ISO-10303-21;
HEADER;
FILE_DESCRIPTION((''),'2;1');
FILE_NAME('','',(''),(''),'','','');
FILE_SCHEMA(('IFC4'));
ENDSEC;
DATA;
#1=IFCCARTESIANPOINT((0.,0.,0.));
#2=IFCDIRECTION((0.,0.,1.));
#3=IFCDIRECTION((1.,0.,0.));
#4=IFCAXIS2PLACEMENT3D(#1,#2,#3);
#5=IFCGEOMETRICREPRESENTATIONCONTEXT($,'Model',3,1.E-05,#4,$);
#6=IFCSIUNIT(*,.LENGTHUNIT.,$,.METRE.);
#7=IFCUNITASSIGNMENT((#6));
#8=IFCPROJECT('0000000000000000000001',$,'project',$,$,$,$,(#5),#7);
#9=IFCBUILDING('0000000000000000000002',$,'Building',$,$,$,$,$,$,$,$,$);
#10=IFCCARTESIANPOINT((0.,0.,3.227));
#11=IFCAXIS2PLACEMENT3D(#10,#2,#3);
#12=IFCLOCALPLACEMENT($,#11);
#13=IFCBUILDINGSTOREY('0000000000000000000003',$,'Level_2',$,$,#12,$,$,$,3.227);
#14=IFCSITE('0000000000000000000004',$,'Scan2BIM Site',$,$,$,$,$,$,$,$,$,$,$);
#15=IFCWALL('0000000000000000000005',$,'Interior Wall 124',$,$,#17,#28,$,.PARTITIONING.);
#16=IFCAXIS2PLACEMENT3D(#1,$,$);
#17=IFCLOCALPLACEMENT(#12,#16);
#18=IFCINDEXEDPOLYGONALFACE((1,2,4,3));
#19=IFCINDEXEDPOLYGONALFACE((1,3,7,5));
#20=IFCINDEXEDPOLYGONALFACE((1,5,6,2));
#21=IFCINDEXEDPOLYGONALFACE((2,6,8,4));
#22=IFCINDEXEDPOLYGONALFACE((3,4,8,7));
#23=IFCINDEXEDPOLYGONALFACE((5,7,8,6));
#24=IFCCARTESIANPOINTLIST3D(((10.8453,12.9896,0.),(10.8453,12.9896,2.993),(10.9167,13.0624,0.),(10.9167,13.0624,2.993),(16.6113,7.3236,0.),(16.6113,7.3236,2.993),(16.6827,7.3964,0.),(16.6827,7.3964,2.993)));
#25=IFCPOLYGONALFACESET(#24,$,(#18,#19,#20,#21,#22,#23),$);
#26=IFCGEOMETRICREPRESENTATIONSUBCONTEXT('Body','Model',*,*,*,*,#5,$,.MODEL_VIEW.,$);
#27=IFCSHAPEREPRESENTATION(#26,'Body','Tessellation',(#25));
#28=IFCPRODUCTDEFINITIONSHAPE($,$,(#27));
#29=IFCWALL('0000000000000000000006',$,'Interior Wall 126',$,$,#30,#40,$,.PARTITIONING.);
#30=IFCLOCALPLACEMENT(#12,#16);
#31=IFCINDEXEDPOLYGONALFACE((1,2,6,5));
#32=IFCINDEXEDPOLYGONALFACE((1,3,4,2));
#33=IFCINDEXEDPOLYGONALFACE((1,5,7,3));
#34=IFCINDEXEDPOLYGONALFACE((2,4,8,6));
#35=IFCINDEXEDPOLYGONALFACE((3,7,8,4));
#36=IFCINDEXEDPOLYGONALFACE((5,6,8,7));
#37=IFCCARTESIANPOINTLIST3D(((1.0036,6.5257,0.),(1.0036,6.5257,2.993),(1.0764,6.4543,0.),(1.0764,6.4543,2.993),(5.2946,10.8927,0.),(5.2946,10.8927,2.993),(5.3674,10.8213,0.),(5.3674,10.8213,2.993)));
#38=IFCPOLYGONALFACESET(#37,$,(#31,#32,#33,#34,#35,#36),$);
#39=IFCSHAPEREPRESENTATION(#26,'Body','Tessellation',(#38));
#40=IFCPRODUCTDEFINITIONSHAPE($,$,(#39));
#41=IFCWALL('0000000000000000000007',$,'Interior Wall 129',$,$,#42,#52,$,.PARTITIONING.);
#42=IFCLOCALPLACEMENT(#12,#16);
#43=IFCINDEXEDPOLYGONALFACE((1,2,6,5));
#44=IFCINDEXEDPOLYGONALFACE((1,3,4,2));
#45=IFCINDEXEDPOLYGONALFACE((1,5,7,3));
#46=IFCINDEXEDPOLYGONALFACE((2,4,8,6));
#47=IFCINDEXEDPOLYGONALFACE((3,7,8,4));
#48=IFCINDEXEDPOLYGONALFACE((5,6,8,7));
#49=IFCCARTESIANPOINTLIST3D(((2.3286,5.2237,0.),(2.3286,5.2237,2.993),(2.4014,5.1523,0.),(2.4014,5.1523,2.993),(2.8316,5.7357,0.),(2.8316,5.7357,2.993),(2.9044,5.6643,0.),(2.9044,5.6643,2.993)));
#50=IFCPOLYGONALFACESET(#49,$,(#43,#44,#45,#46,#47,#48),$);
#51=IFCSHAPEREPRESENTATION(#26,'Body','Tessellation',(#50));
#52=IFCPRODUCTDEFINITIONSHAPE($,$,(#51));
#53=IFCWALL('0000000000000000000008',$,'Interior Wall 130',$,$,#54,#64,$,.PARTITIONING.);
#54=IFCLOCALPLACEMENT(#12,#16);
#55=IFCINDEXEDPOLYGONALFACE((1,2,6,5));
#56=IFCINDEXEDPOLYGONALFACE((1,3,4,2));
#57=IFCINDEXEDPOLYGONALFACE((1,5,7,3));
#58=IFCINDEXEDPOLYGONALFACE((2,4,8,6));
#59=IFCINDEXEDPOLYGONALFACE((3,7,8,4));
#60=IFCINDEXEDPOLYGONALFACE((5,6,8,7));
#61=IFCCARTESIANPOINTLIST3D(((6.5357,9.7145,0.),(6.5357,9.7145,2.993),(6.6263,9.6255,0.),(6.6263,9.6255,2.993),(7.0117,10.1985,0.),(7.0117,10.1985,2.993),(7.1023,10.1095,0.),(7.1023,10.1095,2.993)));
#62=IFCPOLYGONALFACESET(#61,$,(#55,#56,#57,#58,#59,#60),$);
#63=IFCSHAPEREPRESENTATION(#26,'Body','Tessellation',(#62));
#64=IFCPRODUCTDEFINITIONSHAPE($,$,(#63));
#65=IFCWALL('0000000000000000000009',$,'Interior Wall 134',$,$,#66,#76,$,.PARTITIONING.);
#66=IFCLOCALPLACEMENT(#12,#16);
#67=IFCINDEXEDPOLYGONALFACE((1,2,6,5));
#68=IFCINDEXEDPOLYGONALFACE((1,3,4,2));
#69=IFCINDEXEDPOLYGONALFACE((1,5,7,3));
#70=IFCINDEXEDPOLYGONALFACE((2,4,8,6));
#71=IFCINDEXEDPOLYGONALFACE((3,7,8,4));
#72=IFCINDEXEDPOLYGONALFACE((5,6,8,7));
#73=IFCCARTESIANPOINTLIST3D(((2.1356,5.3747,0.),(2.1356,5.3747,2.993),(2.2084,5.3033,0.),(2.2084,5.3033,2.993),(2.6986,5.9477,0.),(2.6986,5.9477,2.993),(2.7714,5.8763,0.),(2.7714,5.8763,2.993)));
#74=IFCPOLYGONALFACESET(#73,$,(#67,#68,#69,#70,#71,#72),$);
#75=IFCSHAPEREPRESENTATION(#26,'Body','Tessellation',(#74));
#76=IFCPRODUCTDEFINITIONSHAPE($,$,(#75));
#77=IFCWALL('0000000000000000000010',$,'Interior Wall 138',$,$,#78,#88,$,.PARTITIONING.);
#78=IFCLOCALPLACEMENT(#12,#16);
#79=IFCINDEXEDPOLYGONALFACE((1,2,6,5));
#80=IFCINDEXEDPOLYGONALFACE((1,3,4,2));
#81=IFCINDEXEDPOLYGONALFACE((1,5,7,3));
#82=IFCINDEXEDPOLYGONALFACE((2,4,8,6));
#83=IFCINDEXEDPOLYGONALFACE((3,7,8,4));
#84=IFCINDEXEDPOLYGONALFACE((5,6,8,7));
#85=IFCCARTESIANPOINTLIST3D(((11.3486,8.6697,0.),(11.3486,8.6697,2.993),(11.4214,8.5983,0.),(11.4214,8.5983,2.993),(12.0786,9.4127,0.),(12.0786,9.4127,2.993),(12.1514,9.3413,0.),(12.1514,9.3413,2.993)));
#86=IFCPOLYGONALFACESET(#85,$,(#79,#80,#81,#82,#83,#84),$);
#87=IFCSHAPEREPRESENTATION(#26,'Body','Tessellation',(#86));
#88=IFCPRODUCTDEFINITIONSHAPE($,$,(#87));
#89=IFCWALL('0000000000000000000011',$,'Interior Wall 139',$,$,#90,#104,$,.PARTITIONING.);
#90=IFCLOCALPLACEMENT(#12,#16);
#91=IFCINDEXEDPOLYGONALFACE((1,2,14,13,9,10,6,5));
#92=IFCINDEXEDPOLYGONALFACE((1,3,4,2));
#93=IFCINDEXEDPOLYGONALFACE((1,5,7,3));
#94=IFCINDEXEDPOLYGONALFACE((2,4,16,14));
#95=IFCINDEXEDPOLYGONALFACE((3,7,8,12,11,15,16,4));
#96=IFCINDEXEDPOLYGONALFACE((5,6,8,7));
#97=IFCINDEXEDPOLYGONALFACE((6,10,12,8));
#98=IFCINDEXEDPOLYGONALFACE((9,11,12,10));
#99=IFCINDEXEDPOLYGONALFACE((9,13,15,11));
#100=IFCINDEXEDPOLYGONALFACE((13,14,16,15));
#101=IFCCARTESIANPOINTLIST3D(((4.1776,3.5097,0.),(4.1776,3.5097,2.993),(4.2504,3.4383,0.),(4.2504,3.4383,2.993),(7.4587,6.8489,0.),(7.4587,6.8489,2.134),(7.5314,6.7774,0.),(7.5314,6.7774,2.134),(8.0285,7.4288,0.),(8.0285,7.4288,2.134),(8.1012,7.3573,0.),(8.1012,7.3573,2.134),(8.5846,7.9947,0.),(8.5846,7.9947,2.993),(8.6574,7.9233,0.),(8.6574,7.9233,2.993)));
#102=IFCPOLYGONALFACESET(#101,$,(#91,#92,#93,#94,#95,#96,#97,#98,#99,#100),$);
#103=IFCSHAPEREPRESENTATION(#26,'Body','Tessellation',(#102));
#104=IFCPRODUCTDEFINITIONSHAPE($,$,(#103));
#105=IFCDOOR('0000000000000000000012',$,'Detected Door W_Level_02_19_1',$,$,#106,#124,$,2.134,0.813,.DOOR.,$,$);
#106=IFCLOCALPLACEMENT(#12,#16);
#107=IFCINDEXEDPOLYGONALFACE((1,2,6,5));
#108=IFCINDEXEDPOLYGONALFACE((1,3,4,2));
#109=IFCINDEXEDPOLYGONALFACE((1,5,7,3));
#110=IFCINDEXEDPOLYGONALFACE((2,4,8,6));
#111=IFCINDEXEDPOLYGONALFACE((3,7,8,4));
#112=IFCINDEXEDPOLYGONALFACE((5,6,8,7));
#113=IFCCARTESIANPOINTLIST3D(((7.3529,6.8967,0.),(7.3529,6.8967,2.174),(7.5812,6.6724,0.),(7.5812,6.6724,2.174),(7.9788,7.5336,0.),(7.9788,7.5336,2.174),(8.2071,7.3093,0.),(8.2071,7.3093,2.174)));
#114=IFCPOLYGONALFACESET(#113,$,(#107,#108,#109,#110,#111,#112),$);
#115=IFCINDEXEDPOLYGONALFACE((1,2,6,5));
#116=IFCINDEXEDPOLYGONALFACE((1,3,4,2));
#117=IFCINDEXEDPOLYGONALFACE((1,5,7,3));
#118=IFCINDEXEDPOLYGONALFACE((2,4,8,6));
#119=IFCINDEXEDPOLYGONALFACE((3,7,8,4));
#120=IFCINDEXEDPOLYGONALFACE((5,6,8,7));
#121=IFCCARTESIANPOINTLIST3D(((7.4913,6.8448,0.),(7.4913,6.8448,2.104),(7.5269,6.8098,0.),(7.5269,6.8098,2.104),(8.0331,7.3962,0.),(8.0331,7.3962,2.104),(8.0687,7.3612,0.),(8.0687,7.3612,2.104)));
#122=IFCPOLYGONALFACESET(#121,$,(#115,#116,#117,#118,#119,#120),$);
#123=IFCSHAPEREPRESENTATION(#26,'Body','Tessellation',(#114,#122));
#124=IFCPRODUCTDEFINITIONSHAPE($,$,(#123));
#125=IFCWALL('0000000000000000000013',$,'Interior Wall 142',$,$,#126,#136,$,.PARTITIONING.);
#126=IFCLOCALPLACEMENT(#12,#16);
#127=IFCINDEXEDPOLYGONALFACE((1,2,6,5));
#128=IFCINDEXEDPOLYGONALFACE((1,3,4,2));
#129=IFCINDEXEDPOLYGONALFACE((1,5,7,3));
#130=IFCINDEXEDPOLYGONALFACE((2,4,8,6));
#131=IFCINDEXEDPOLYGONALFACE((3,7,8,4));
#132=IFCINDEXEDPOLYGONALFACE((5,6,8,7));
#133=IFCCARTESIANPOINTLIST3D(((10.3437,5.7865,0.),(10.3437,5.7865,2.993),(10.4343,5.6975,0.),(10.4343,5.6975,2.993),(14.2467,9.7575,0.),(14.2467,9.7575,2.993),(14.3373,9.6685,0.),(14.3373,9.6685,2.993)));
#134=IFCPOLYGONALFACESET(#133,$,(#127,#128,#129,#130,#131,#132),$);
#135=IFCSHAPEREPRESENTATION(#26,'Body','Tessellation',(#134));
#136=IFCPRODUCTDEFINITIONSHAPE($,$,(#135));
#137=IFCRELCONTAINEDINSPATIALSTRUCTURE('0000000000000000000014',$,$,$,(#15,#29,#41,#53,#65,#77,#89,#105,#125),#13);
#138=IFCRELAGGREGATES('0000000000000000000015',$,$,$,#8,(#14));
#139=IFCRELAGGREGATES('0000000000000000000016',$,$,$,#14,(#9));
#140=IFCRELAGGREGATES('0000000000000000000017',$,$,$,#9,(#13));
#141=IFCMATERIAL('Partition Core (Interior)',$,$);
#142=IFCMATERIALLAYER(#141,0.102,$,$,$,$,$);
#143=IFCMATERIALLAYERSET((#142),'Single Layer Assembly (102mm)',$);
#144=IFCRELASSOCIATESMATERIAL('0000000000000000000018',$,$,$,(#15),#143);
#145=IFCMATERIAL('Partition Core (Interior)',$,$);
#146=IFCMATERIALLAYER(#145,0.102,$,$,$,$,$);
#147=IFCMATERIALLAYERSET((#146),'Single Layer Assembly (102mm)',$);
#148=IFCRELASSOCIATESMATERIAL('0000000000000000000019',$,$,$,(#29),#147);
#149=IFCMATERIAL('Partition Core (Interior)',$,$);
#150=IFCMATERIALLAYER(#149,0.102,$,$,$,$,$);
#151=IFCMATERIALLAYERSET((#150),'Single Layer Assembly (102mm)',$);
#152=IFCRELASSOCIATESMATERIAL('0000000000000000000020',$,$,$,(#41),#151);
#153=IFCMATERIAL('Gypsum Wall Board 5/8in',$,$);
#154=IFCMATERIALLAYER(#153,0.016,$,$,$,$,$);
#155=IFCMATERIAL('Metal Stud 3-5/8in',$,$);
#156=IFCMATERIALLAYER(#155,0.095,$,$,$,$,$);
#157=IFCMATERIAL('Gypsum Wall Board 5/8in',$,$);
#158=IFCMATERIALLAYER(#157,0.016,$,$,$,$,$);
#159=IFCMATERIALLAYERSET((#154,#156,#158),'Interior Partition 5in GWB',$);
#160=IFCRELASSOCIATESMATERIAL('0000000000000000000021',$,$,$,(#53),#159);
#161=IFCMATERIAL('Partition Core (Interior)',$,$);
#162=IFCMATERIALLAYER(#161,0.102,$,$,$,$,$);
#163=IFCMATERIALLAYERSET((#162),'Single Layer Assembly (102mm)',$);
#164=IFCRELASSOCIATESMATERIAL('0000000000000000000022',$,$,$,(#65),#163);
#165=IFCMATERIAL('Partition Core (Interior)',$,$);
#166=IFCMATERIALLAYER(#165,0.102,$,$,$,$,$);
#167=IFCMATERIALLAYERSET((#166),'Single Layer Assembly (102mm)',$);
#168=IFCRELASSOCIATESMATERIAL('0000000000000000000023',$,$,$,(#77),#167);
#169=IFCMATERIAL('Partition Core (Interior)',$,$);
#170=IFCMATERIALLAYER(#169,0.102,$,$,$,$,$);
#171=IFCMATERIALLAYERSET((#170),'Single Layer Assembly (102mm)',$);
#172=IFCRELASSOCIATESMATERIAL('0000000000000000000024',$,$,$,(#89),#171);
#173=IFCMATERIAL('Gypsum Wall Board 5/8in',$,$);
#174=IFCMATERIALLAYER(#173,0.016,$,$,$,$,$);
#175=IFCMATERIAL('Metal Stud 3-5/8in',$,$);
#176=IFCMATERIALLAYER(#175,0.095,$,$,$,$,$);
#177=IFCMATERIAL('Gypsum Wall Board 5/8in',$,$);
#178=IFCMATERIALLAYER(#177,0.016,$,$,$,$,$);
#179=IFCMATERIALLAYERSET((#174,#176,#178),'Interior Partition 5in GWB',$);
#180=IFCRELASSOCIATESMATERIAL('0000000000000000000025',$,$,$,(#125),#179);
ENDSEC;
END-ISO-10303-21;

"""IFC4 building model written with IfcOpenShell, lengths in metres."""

from ifc_helpers import new_model, si_unit, frame, origin, origin_with_axes, place, context, subcontext, project, spatial, rectangle, extrude, material, layer, layer_set, element, fill, save


model = new_model("IFC4")

# Units and contexts
model_context = context("Model", 3, precision=1e-05, world=origin_with_axes())
body_context = subcontext(model_context, "Body", "Model", "MODEL_VIEW")
ifc_project = project(units=[si_unit("LENGTHUNIT", "METRE")], contexts=[model_context])

# Site, building, storey
site = spatial("IfcSite", under=ifc_project, Name="Scan2BIM Site")
building = spatial("IfcBuilding", under=site, Name="Building")
storey_placement = place(None, frame((0.0, 0.0, 3.227), z_axis=(0.0, 0.0, 1.0), x_axis=(1.0, 0.0, 0.0)))
storey = spatial("IfcBuildingStorey", under=building, at=storey_placement, Name="Level_2", Elevation=3.227)

# Walls
ifc_material_1 = material(Name="Partition Core (Interior)")
ifc_layer_1 = layer(ifc_material_1, 0.102)
ifc_layer_set_1 = layer_set([ifc_layer_1], Name="Single Layer Assembly (102mm)")
wall_1_placement = place(storey_placement, frame((13.764, 10.193, 0.0), z_axis=(0.0, 0.0, 1.0), x_axis=(0.713265, -0.700895, 0.0)))
element("IfcWall", 1, at=wall_1_placement, inside=storey, material=ifc_layer_set_1, Name="Interior Wall 124", PredefinedType="PARTITIONING", context=body_context, shape_type="SweptSolid", body=[
    extrude(rectangle(XDim=8.084, YDim=0.102), origin(), (0.0, 0.0, 1.0), 2.993),
])
ifc_material_2 = material(Name="Partition Core (Interior)")
ifc_layer_2 = layer(ifc_material_2, 0.102)
ifc_layer_set_2 = layer_set([ifc_layer_2], Name="Single Layer Assembly (102mm)")
wall_2_placement = place(storey_placement, frame((3.1855, 8.6735, 0.0), z_axis=(0.0, 0.0, 1.0), x_axis=(0.700873, 0.713286, 0.0)))
element("IfcWall", 2, at=wall_2_placement, inside=storey, material=ifc_layer_set_2, Name="Interior Wall 126", PredefinedType="PARTITIONING", context=body_context, shape_type="SweptSolid", body=[
    extrude(rectangle(XDim=6.1224, YDim=0.102), origin(), (0.0, 0.0, 1.0), 2.993),
])
ifc_material_3 = material(Name="Partition Core (Interior)")
ifc_layer_3 = layer(ifc_material_3, 0.102)
ifc_layer_set_3 = layer_set([ifc_layer_3], Name="Single Layer Assembly (102mm)")
wall_3_placement = place(storey_placement, frame((2.6165, 5.444, 0.0), z_axis=(0.0, 0.0, 1.0), x_axis=(-0.700809, -0.713349, 0.0)))
element("IfcWall", 3, at=wall_3_placement, inside=storey, material=ifc_layer_set_3, Name="Interior Wall 129", PredefinedType="PARTITIONING", context=body_context, shape_type="SweptSolid", body=[
    extrude(rectangle(XDim=0.7177, YDim=0.102), origin(), (0.0, 0.0, 1.0), 2.993),
])
ifc_material_4 = material(Name="Gypsum Wall Board 5/8in")
ifc_layer_4 = layer(ifc_material_4, 0.016)
ifc_material_5 = material(Name="Metal Stud 3-5/8in")
ifc_layer_5 = layer(ifc_material_5, 0.095)
ifc_material_6 = material(Name="Gypsum Wall Board 5/8in")
ifc_layer_6 = layer(ifc_material_6, 0.016)
ifc_layer_set_4 = layer_set([ifc_layer_4, ifc_layer_5, ifc_layer_6], Name="Interior Partition 5in GWB")
wall_4_placement = place(storey_placement, frame((6.819, 9.912, 0.0), z_axis=(0.0, 0.0, 1.0), x_axis=(0.70119, 0.712975, 0.0)))
element("IfcWall", 4, at=wall_4_placement, inside=storey, material=ifc_layer_set_4, Name="Interior Wall 130", PredefinedType="PARTITIONING", context=body_context, shape_type="SweptSolid", body=[
    extrude(rectangle(XDim=0.6788, YDim=0.127), origin(), (0.0, 0.0, 1.0), 2.993),
])
ifc_material_7 = material(Name="Partition Core (Interior)")
ifc_layer_7 = layer(ifc_material_7, 0.102)
ifc_layer_set_5 = layer_set([ifc_layer_7], Name="Single Layer Assembly (102mm)")
wall_5_placement = place(storey_placement, frame((2.4535, 5.6255, 0.0), z_axis=(0.0, 0.0, 1.0), x_axis=(0.700855, 0.713304, 0.0)))
element("IfcWall", 5, at=wall_5_placement, inside=storey, material=ifc_layer_set_5, Name="Interior Wall 134", PredefinedType="PARTITIONING", context=body_context, shape_type="SweptSolid", body=[
    extrude(rectangle(XDim=0.8033, YDim=0.102), origin(), (0.0, 0.0, 1.0), 2.993),
])
ifc_material_8 = material(Name="Partition Core (Interior)")
ifc_layer_8 = layer(ifc_material_8, 0.102)
ifc_layer_set_6 = layer_set([ifc_layer_8], Name="Single Layer Assembly (102mm)")
wall_6_placement = place(storey_placement, frame((11.75, 9.0055, 0.0), z_axis=(0.0, 0.0, 1.0), x_axis=(0.700839, 0.71332, 0.0)))
element("IfcWall", 6, at=wall_6_placement, inside=storey, material=ifc_layer_set_6, Name="Interior Wall 138", PredefinedType="PARTITIONING", context=body_context, shape_type="SweptSolid", body=[
    extrude(rectangle(XDim=1.0416, YDim=0.102), origin(), (0.0, 0.0, 1.0), 2.993),
])

# Wall, opening, door
ifc_material_9 = material(Name="Partition Core (Interior)")
ifc_layer_9 = layer(ifc_material_9, 0.102)
ifc_layer_set_7 = layer_set([ifc_layer_9], Name="Single Layer Assembly (102mm)")
wall_7_placement = place(storey_placement, frame((6.4175, 5.7165, 0.0), z_axis=(0.0, 0.0, 1.0), x_axis=(-0.700877, -0.713282, 0.0)))
wall_7 = element("IfcWall", 7, at=wall_7_placement, inside=storey, material=ifc_layer_set_7, Name="Interior Wall 139", PredefinedType="PARTITIONING", context=body_context, shape_type="SweptSolid", body=[
    extrude(rectangle(XDim=6.2878, YDim=0.102), origin(), (0.0, 0.0, 1.0), 2.993),
])
opening_1_placement = place(None, frame((7.78, 7.103, 3.227), z_axis=(0.0, 0.0, 1.0), x_axis=(-0.700877, -0.713282, 0.0)))
opening_1 = element("IfcOpeningElement", 8, at=opening_1_placement, cuts=wall_7, PredefinedType="OPENING", context=body_context, shape_type="SweptSolid", body=[
    extrude(rectangle(XDim=0.813, YDim=0.202), origin(), (0.0, 0.0, 1.0), 2.134),
])
door_1_placement = place(opening_1_placement, frame((0.0, 0.0, 0.0), z_axis=(0.0, 0.0, 1.0), x_axis=(1.0, 0.0, 0.0)))
door_1 = element("IfcDoor", 9, at=door_1_placement, inside=storey, Name="Detected Door W_Level_02_19_1", OverallHeight=2.134, OverallWidth=0.813, PredefinedType="DOOR", context=body_context, shape_type="SweptSolid", body=[
    extrude(rectangle(XDim=0.893, YDim=0.32), origin(), (0.0, 0.0, 1.0), 2.174),
    extrude(rectangle(XDim=0.773, YDim=0.05), origin(), (0.0, 0.0, 1.0), 2.104),
])
fill(opening_1, door_1)

# Wall
ifc_material_10 = material(Name="Gypsum Wall Board 5/8in")
ifc_layer_10 = layer(ifc_material_10, 0.016)
ifc_material_11 = material(Name="Metal Stud 3-5/8in")
ifc_layer_11 = layer(ifc_material_11, 0.095)
ifc_material_12 = material(Name="Gypsum Wall Board 5/8in")
ifc_layer_12 = layer(ifc_material_12, 0.016)
ifc_layer_set_8 = layer_set([ifc_layer_10, ifc_layer_11, ifc_layer_12], Name="Interior Partition 5in GWB")
wall_8_placement = place(storey_placement, frame((12.3405, 7.7275, 0.0), z_axis=(0.0, 0.0, 1.0), x_axis=(-0.700974, -0.713187, 0.0)))
element("IfcWall", 10, at=wall_8_placement, inside=storey, material=ifc_layer_set_8, Name="Interior Wall 142", PredefinedType="PARTITIONING", context=body_context, shape_type="SweptSolid", body=[
    extrude(rectangle(XDim=5.568, YDim=0.127), origin(), (0.0, 0.0, 1.0), 2.993),
])

save(model, "model.ifc")
